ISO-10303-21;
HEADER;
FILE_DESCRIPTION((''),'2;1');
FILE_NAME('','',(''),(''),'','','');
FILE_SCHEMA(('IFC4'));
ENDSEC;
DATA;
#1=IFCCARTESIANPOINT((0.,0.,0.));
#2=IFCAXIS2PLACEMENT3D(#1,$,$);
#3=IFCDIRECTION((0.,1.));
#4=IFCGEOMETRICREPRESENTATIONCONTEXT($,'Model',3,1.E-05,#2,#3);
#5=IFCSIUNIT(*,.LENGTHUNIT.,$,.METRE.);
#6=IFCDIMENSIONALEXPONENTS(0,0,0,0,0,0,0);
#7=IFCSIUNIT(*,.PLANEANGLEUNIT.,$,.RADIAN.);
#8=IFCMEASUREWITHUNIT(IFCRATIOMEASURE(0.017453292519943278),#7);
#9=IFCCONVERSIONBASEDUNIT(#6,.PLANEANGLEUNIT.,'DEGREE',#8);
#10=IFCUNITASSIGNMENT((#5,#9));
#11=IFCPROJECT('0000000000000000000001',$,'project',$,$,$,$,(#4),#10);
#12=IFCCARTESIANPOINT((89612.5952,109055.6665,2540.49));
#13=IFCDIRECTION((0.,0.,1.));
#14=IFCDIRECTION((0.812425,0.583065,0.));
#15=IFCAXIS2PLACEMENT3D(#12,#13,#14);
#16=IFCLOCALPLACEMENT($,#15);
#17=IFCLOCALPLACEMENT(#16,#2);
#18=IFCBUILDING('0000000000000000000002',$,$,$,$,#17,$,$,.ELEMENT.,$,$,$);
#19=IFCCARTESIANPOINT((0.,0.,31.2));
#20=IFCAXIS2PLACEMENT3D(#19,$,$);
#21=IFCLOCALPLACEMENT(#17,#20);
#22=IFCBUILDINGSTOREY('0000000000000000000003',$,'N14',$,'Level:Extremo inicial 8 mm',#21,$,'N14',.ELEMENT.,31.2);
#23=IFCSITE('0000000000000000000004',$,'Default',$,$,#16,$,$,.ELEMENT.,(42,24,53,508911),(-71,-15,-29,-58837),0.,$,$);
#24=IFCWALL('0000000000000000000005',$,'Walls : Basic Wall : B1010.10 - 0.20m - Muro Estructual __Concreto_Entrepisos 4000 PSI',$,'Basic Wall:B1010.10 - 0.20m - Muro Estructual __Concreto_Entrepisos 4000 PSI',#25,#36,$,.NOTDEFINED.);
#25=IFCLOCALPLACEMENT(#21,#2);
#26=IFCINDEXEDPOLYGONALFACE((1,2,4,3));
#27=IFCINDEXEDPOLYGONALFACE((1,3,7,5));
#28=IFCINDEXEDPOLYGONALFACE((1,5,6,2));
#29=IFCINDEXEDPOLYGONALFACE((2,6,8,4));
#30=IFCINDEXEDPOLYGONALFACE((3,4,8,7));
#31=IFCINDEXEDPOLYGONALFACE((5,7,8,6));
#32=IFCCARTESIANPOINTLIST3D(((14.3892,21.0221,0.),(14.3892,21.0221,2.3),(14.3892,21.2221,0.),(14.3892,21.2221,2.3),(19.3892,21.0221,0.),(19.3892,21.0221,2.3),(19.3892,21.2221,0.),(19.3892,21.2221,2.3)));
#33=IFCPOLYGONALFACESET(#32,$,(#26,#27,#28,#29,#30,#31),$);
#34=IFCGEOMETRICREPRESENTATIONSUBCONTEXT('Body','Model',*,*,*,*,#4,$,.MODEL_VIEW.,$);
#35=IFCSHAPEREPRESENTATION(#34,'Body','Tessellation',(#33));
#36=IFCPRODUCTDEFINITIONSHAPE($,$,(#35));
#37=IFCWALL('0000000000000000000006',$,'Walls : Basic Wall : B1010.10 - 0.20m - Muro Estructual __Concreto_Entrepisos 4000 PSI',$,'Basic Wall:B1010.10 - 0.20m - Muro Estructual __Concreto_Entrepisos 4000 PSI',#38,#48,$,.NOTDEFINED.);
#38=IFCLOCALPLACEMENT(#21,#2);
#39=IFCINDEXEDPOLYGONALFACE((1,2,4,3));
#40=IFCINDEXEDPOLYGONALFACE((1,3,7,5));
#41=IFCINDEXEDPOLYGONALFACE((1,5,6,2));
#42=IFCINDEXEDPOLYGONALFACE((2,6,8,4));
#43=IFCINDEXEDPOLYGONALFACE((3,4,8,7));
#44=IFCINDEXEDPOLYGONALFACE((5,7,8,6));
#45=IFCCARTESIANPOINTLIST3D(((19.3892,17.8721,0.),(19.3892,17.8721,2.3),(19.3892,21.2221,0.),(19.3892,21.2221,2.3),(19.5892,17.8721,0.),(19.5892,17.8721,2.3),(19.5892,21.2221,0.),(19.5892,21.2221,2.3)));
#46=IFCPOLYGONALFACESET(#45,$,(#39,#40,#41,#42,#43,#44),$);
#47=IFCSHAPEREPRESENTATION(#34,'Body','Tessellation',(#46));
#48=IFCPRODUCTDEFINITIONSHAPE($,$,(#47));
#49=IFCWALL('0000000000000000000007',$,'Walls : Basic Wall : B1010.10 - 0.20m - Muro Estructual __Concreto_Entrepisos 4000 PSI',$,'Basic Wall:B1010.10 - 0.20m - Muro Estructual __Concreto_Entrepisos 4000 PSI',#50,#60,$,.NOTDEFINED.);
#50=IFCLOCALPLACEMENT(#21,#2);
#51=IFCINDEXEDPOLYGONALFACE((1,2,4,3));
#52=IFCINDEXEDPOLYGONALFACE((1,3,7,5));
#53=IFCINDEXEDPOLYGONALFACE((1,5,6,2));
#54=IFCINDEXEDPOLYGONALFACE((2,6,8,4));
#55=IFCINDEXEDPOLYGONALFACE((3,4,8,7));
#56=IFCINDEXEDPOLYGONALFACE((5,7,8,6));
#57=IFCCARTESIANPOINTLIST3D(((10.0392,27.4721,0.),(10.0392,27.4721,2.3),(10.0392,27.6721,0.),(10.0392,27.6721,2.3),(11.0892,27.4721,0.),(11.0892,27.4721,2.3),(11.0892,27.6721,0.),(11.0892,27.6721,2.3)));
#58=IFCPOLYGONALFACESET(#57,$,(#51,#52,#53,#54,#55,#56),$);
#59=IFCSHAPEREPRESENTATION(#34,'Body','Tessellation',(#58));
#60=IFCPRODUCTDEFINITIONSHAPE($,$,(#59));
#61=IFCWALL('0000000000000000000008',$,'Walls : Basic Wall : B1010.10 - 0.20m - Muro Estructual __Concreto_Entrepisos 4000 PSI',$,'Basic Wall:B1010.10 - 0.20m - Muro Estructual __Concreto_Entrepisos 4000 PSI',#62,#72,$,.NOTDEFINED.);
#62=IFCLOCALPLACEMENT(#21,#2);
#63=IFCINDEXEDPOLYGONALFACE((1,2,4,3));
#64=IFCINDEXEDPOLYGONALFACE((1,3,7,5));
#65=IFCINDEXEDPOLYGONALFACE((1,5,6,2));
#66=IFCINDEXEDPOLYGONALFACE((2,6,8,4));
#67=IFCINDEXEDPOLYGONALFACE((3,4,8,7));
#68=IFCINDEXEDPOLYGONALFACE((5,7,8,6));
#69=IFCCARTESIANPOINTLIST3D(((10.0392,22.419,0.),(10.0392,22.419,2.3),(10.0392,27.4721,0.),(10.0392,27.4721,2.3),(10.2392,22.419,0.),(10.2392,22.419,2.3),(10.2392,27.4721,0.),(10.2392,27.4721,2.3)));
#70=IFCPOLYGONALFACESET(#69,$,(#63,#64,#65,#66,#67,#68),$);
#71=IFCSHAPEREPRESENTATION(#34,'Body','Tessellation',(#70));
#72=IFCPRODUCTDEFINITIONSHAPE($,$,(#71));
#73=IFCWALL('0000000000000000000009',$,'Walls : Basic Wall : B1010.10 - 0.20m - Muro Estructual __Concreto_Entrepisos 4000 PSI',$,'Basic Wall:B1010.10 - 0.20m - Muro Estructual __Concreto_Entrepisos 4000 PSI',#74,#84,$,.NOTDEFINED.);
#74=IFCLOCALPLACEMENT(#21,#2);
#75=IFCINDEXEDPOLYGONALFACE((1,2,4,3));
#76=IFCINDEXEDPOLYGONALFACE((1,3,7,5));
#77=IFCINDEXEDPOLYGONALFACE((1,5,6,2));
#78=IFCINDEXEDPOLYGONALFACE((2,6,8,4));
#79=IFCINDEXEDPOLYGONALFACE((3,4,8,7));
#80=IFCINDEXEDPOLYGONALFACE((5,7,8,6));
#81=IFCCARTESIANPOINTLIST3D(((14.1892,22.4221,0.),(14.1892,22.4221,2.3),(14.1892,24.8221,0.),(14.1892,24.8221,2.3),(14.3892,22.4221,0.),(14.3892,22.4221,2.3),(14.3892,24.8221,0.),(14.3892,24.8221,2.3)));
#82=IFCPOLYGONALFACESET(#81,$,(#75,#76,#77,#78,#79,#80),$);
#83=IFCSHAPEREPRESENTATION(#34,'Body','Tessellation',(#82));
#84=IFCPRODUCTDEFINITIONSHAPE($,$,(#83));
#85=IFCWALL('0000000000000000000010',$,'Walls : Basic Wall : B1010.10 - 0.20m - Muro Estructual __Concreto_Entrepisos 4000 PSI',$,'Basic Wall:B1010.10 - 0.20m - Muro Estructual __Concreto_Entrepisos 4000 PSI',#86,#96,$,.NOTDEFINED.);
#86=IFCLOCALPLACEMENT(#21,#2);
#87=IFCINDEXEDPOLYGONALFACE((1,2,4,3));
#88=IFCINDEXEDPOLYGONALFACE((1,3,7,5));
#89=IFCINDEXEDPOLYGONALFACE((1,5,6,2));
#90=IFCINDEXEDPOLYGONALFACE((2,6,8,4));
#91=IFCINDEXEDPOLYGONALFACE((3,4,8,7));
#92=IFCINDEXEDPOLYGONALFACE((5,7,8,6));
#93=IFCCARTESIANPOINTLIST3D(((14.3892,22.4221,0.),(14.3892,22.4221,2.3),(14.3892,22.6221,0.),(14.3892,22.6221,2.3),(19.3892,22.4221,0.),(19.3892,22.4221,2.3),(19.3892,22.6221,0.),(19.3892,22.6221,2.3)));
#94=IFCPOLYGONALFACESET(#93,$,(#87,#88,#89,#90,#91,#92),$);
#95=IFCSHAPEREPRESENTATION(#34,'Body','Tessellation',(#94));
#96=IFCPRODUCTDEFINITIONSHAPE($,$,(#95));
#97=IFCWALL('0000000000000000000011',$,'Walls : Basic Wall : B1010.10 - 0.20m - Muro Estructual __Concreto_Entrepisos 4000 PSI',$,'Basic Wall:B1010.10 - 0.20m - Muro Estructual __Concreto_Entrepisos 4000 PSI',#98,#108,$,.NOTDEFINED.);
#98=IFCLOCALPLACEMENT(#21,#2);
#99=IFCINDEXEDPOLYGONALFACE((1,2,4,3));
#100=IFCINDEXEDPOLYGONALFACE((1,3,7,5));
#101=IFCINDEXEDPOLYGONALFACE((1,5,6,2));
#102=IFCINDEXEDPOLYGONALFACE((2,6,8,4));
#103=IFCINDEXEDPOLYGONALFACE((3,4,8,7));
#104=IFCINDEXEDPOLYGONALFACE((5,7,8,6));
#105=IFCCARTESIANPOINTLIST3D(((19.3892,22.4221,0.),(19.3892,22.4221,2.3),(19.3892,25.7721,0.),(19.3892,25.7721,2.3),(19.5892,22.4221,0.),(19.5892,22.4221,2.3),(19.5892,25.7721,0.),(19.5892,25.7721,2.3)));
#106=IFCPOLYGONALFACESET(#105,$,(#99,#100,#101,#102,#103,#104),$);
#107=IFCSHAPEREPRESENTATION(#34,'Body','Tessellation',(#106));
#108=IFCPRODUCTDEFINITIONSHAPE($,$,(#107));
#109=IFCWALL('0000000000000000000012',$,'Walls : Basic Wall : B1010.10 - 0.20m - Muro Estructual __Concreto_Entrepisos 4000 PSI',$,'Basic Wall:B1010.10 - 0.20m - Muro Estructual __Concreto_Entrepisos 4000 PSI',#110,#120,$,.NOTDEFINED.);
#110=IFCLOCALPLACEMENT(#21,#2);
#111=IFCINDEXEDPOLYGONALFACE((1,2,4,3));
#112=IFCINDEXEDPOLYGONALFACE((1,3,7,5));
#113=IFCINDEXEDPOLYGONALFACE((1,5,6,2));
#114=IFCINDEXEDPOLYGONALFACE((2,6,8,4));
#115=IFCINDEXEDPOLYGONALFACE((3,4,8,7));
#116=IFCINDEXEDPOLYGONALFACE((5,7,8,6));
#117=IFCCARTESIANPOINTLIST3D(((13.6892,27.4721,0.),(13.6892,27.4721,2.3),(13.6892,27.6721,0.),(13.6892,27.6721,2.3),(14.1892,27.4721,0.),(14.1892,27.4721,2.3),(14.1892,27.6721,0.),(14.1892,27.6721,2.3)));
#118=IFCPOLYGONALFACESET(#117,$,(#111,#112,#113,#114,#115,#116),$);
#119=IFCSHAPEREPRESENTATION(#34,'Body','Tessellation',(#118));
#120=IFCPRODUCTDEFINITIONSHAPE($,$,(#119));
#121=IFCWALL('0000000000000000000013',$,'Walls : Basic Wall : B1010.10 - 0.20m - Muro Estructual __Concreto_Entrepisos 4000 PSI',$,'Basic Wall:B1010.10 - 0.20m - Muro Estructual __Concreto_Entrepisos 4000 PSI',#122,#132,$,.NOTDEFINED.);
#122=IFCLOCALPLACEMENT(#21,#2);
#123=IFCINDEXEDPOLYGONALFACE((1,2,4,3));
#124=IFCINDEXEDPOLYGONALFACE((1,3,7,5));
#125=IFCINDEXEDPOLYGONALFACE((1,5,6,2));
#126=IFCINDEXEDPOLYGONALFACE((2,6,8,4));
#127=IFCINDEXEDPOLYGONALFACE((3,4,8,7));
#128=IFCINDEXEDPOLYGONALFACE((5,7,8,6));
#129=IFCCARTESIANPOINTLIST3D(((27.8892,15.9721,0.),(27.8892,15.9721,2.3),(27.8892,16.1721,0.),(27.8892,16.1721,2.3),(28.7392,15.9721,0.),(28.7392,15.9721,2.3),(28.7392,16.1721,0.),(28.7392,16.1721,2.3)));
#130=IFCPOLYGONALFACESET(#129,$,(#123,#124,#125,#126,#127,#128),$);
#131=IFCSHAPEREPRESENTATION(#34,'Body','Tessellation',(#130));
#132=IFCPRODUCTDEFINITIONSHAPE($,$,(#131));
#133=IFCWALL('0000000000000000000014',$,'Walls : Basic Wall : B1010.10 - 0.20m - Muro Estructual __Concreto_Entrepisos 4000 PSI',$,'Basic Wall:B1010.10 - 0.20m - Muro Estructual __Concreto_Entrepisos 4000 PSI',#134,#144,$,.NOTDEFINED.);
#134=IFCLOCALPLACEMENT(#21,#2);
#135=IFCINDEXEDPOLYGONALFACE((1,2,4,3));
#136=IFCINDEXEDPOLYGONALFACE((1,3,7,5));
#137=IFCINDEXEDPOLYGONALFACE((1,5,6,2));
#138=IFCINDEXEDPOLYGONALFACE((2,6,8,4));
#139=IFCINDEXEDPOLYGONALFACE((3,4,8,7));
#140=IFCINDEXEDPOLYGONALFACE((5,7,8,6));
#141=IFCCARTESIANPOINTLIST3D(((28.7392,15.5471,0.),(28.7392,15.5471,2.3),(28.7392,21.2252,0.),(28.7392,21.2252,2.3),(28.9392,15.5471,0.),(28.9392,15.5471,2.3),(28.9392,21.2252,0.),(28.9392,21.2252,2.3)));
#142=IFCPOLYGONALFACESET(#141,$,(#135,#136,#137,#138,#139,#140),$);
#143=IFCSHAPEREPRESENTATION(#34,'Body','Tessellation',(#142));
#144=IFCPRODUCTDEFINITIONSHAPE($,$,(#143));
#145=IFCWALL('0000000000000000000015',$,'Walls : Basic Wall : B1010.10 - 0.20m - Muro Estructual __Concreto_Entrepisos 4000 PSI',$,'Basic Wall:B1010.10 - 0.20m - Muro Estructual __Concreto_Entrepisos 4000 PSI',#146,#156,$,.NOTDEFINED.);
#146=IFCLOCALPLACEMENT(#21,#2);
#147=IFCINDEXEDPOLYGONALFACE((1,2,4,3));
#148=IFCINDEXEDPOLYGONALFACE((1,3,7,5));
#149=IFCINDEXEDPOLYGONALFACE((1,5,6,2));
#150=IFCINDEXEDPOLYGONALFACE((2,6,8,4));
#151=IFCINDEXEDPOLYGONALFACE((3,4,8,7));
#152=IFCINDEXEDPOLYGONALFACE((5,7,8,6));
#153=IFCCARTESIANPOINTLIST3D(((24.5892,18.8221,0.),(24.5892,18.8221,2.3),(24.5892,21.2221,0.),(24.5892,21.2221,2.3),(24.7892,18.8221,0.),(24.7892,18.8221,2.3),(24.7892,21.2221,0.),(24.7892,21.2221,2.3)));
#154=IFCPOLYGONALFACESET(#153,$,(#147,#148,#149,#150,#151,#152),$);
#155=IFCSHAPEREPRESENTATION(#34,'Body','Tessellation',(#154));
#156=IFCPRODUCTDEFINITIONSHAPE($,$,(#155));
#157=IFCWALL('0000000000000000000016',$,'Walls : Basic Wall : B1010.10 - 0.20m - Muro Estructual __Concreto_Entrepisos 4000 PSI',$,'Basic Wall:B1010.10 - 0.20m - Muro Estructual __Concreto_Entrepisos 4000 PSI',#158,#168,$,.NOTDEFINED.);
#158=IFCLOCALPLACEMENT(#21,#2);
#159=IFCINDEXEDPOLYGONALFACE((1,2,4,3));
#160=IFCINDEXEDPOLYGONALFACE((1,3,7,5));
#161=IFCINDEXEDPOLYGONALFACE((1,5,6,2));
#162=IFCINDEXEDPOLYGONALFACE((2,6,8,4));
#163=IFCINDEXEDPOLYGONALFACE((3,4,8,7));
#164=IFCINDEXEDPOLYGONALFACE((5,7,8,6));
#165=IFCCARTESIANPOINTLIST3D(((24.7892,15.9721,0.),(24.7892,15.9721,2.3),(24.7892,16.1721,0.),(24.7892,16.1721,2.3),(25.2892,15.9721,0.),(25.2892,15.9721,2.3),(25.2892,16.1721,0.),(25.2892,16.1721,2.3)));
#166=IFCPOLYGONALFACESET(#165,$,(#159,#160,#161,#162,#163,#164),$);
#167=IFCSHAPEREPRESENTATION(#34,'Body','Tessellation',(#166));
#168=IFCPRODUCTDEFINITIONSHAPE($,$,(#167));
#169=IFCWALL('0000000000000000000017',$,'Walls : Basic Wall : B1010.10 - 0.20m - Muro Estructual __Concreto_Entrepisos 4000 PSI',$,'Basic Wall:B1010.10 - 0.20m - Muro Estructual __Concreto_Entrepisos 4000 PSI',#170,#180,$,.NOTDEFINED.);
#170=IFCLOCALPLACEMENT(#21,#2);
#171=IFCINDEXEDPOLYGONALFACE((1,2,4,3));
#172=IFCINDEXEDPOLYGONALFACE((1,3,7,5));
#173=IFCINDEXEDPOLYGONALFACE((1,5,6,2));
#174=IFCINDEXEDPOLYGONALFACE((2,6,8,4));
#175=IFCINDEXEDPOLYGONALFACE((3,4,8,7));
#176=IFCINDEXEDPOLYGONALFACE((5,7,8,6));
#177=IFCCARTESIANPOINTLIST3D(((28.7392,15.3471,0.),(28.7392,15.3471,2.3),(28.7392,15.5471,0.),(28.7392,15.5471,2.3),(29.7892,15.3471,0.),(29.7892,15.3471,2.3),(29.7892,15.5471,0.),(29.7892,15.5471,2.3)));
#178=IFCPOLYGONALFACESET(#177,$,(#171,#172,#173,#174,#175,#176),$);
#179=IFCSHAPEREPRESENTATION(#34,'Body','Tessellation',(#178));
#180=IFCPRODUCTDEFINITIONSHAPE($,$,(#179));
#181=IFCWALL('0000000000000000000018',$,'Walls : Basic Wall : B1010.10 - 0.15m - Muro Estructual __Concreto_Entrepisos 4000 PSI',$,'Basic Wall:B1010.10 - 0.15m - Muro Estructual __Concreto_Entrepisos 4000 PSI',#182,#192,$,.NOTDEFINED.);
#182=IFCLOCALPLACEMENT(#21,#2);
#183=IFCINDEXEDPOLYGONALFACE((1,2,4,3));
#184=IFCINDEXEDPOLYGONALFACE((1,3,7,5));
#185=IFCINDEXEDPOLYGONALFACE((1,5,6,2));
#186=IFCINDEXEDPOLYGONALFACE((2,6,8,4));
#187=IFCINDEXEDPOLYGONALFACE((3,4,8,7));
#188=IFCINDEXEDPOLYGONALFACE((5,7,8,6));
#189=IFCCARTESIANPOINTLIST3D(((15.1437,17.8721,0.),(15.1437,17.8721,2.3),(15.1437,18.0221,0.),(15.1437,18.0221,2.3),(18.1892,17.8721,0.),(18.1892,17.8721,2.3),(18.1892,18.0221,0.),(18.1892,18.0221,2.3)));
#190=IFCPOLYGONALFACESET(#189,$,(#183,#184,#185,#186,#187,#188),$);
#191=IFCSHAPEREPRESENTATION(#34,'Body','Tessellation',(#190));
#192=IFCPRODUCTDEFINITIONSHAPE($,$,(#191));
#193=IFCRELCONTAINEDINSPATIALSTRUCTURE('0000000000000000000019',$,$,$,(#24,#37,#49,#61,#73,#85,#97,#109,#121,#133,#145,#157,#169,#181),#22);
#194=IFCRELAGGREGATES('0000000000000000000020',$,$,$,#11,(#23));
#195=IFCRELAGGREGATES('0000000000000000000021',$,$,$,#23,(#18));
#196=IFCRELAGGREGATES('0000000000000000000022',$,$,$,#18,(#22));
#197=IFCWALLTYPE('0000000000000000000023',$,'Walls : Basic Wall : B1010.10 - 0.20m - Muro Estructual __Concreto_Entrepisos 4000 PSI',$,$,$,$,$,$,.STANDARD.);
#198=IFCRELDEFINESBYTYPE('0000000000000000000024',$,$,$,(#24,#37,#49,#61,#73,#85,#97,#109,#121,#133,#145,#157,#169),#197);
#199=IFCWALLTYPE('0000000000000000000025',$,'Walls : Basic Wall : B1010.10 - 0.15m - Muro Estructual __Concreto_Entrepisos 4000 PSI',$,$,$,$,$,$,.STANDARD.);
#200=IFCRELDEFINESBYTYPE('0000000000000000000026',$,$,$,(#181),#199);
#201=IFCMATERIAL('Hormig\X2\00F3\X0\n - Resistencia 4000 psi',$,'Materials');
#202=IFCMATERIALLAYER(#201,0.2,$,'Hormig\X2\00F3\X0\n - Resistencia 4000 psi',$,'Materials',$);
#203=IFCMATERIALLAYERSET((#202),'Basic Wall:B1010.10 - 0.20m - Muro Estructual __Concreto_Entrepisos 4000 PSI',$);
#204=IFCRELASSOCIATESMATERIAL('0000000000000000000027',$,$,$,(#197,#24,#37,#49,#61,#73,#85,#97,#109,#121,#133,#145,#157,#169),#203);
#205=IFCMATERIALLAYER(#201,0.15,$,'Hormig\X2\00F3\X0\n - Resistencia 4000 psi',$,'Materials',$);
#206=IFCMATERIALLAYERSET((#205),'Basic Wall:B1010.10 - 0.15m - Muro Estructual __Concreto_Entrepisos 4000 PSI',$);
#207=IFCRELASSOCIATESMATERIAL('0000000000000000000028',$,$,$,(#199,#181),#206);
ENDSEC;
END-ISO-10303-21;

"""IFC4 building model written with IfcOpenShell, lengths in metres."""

from ifc_helpers import new_model, entity, si_unit, converted_unit, direction, frame, frame_2d, origin, place, context, subcontext, project, spatial, rectangle, extrude, material, layer, layer_set, layer_usage, type_object, element, save


model = new_model("IFC4")

# Units and contexts
model_context = context("Model", 3, precision=1e-05, world=origin(), true_north=direction((0.0, 1.0)))
body_context = subcontext(model_context, "Body", "Model", "MODEL_VIEW")
ifc_project = project(units=[si_unit("LENGTHUNIT", "METRE"), converted_unit("PLANEANGLEUNIT", "DEGREE", entity("IfcRatioMeasure", 0.017453292519943278), si_unit("PLANEANGLEUNIT", "RADIAN"), dimensions=[0, 0, 0, 0, 0, 0, 0])], contexts=[model_context])

# Site, building, storey
site_placement = place(None, frame((89612.5952, 109055.6665, 2540.49), z_axis=(0.0, 0.0, 1.0), x_axis=(0.812425, 0.583065, 0.0)))
site = spatial("IfcSite", under=ifc_project, at=site_placement, Name="Default", CompositionType="ELEMENT", RefLatitude=(42, 24, 53, 508911), RefLongitude=(-71, -15, -29, -58837), RefElevation=0.0)
building_placement = place(site_placement, origin())
building = spatial("IfcBuilding", under=site, at=building_placement, CompositionType="ELEMENT")
storey_placement = place(building_placement, frame((0.0, 0.0, 31.2)))
storey = spatial("IfcBuildingStorey", under=building, at=storey_placement, Name="N14", ObjectType="Level:Extremo inicial 8 mm", LongName="N14", CompositionType="ELEMENT", Elevation=31.2)

# Walls
ifc_material = material(Name="Hormigón - Resistencia 4000 psi", Category="Materials")
ifc_layer_1 = layer(ifc_material, 0.2, Name="Hormigón - Resistencia 4000 psi", Category="Materials")
ifc_layer_set_1 = layer_set([ifc_layer_1], Name="Basic Wall:B1010.10 - 0.20m - Muro Estructual __Concreto_Entrepisos 4000 PSI")
ifc_layer_usage_1 = layer_usage(ifc_layer_set_1, "AXIS2", "NEGATIVE", 0.1)
wall_type_1 = type_object("IfcWallType", Name="Walls : Basic Wall : B1010.10 - 0.20m - Muro Estructual __Concreto_Entrepisos 4000 PSI", PredefinedType="STANDARD", material=ifc_layer_set_1)
wall_1_placement = place(storey_placement, frame((14.3892, 21.1221, 0.0)))
element("IfcWall", 1, at=wall_1_placement, inside=storey, type_object=wall_type_1, material=ifc_layer_usage_1, Name="Walls : Basic Wall : B1010.10 - 0.20m - Muro Estructual __Concreto_Entrepisos 4000 PSI", ObjectType="Basic Wall:B1010.10 - 0.20m - Muro Estructual __Concreto_Entrepisos 4000 PSI", PredefinedType="NOTDEFINED", context=body_context, shape_type="SweptSolid", body=[
    extrude(rectangle(XDim=5.0, YDim=0.2, at=frame_2d((2.5, 0.0), x_axis=(-1.0, 0.0))), origin(), (0.0, 0.0, 1.0), 2.3),
])
ifc_layer_usage_2 = layer_usage(ifc_layer_set_1, "AXIS2", "NEGATIVE", 0.1)
wall_2_placement = place(storey_placement, frame((19.4892, 21.2221, 0.0), z_axis=(0.0, 0.0, 1.0), x_axis=(0.0, -1.0, 0.0)))
element("IfcWall", 2, at=wall_2_placement, inside=storey, type_object=wall_type_1, material=ifc_layer_usage_2, Name="Walls : Basic Wall : B1010.10 - 0.20m - Muro Estructual __Concreto_Entrepisos 4000 PSI", ObjectType="Basic Wall:B1010.10 - 0.20m - Muro Estructual __Concreto_Entrepisos 4000 PSI", PredefinedType="NOTDEFINED", context=body_context, shape_type="SweptSolid", body=[
    extrude(rectangle(XDim=3.35, YDim=0.2, at=frame_2d((1.675, 0.0), x_axis=(-1.0, 0.0))), origin(), (0.0, 0.0, 1.0), 2.3),
])
ifc_layer_usage_3 = layer_usage(ifc_layer_set_1, "AXIS2", "POSITIVE", -0.1)
wall_3_placement = place(storey_placement, frame((11.0892, 27.5721, 0.0), z_axis=(0.0, 0.0, 1.0), x_axis=(-1.0, 0.0, 0.0)))
element("IfcWall", 3, at=wall_3_placement, inside=storey, type_object=wall_type_1, material=ifc_layer_usage_3, Name="Walls : Basic Wall : B1010.10 - 0.20m - Muro Estructual __Concreto_Entrepisos 4000 PSI", ObjectType="Basic Wall:B1010.10 - 0.20m - Muro Estructual __Concreto_Entrepisos 4000 PSI", PredefinedType="NOTDEFINED", context=body_context, shape_type="SweptSolid", body=[
    extrude(rectangle(XDim=1.05, YDim=0.2, at=frame_2d((0.525, 0.0), x_axis=(-1.0, 0.0))), origin(), (0.0, 0.0, 1.0), 2.3),
])
ifc_layer_usage_4 = layer_usage(ifc_layer_set_1, "AXIS2", "POSITIVE", -0.1)
wall_4_placement = place(storey_placement, frame((10.1392, 27.4721, 0.0), z_axis=(0.0, 0.0, 1.0), x_axis=(0.0, -1.0, 0.0)))
element("IfcWall", 4, at=wall_4_placement, inside=storey, type_object=wall_type_1, material=ifc_layer_usage_4, Name="Walls : Basic Wall : B1010.10 - 0.20m - Muro Estructual __Concreto_Entrepisos 4000 PSI", ObjectType="Basic Wall:B1010.10 - 0.20m - Muro Estructual __Concreto_Entrepisos 4000 PSI", PredefinedType="NOTDEFINED", context=body_context, shape_type="SweptSolid", body=[
    extrude(rectangle(XDim=5.0531, YDim=0.2, at=frame_2d((2.5265, 0.0), x_axis=(-1.0, 0.0))), origin(), (0.0, 0.0, 1.0), 2.3),
])
ifc_layer_usage_5 = layer_usage(ifc_layer_set_1, "AXIS2", "POSITIVE", -0.1)
wall_5_placement = place(storey_placement, frame((14.2892, 24.8221, 0.0), z_axis=(0.0, 0.0, 1.0), x_axis=(0.0, -1.0, 0.0)))
element("IfcWall", 5, at=wall_5_placement, inside=storey, type_object=wall_type_1, material=ifc_layer_usage_5, Name="Walls : Basic Wall : B1010.10 - 0.20m - Muro Estructual __Concreto_Entrepisos 4000 PSI", ObjectType="Basic Wall:B1010.10 - 0.20m - Muro Estructual __Concreto_Entrepisos 4000 PSI", PredefinedType="NOTDEFINED", context=body_context, shape_type="SweptSolid", body=[
    extrude(rectangle(XDim=2.4, YDim=0.2, at=frame_2d((1.2, 0.0), x_axis=(-1.0, 0.0))), origin(), (0.0, 0.0, 1.0), 2.3),
])
ifc_layer_usage_6 = layer_usage(ifc_layer_set_1, "AXIS2", "POSITIVE", -0.1)
wall_6_placement = place(storey_placement, frame((14.3892, 22.5221, 0.0)))
element("IfcWall", 6, at=wall_6_placement, inside=storey, type_object=wall_type_1, material=ifc_layer_usage_6, Name="Walls : Basic Wall : B1010.10 - 0.20m - Muro Estructual __Concreto_Entrepisos 4000 PSI", ObjectType="Basic Wall:B1010.10 - 0.20m - Muro Estructual __Concreto_Entrepisos 4000 PSI", PredefinedType="NOTDEFINED", context=body_context, shape_type="SweptSolid", body=[
    extrude(rectangle(XDim=5.0, YDim=0.2, at=frame_2d((2.5, 0.0), x_axis=(-1.0, 0.0))), origin(), (0.0, 0.0, 1.0), 2.3),
])
ifc_layer_usage_7 = layer_usage(ifc_layer_set_1, "AXIS2", "POSITIVE", -0.1)
wall_7_placement = place(storey_placement, frame((19.4892, 22.4221, 0.0), z_axis=(0.0, 0.0, 1.0), x_axis=(0.0, 1.0, 0.0)))
element("IfcWall", 7, at=wall_7_placement, inside=storey, type_object=wall_type_1, material=ifc_layer_usage_7, Name="Walls : Basic Wall : B1010.10 - 0.20m - Muro Estructual __Concreto_Entrepisos 4000 PSI", ObjectType="Basic Wall:B1010.10 - 0.20m - Muro Estructual __Concreto_Entrepisos 4000 PSI", PredefinedType="NOTDEFINED", context=body_context, shape_type="SweptSolid", body=[
    extrude(rectangle(XDim=3.35, YDim=0.2, at=frame_2d((1.675, 0.0), x_axis=(-1.0, 0.0))), origin(), (0.0, 0.0, 1.0), 2.3),
])
ifc_layer_usage_8 = layer_usage(ifc_layer_set_1, "AXIS2", "POSITIVE", -0.1)
wall_8_placement = place(storey_placement, frame((13.6892, 27.5721, 0.0)))
element("IfcWall", 8, at=wall_8_placement, inside=storey, type_object=wall_type_1, material=ifc_layer_usage_8, Name="Walls : Basic Wall : B1010.10 - 0.20m - Muro Estructual __Concreto_Entrepisos 4000 PSI", ObjectType="Basic Wall:B1010.10 - 0.20m - Muro Estructual __Concreto_Entrepisos 4000 PSI", PredefinedType="NOTDEFINED", context=body_context, shape_type="SweptSolid", body=[
    extrude(rectangle(XDim=0.5, YDim=0.2, at=frame_2d((0.25, 0.0), x_axis=(-1.0, 0.0))), origin(), (0.0, 0.0, 1.0), 2.3),
])
ifc_layer_usage_9 = layer_usage(ifc_layer_set_1, "AXIS2", "POSITIVE", -0.1)
wall_9_placement = place(storey_placement, frame((27.8892, 16.0721, 0.0)))
element("IfcWall", 9, at=wall_9_placement, inside=storey, type_object=wall_type_1, material=ifc_layer_usage_9, Name="Walls : Basic Wall : B1010.10 - 0.20m - Muro Estructual __Concreto_Entrepisos 4000 PSI", ObjectType="Basic Wall:B1010.10 - 0.20m - Muro Estructual __Concreto_Entrepisos 4000 PSI", PredefinedType="NOTDEFINED", context=body_context, shape_type="SweptSolid", body=[
    extrude(rectangle(XDim=0.85, YDim=0.2, at=frame_2d((0.425, 0.0), x_axis=(-1.0, 0.0))), origin(), (0.0, 0.0, 1.0), 2.3),
])
ifc_layer_usage_10 = layer_usage(ifc_layer_set_1, "AXIS2", "POSITIVE", -0.1)
wall_10_placement = place(storey_placement, frame((28.8392, 15.5471, 0.0), z_axis=(0.0, 0.0, 1.0), x_axis=(0.0, 1.0, 0.0)))
element("IfcWall", 10, at=wall_10_placement, inside=storey, type_object=wall_type_1, material=ifc_layer_usage_10, Name="Walls : Basic Wall : B1010.10 - 0.20m - Muro Estructual __Concreto_Entrepisos 4000 PSI", ObjectType="Basic Wall:B1010.10 - 0.20m - Muro Estructual __Concreto_Entrepisos 4000 PSI", PredefinedType="NOTDEFINED", context=body_context, shape_type="SweptSolid", body=[
    extrude(rectangle(XDim=5.6781, YDim=0.2, at=frame_2d((2.839, 0.0), x_axis=(-1.0, 0.0))), origin(), (0.0, 0.0, 1.0), 2.3),
])
ifc_layer_usage_11 = layer_usage(ifc_layer_set_1, "AXIS2", "POSITIVE", -0.1)
wall_11_placement = place(storey_placement, frame((24.6892, 18.8221, 0.0), z_axis=(0.0, 0.0, 1.0), x_axis=(0.0, 1.0, 0.0)))
element("IfcWall", 11, at=wall_11_placement, inside=storey, type_object=wall_type_1, material=ifc_layer_usage_11, Name="Walls : Basic Wall : B1010.10 - 0.20m - Muro Estructual __Concreto_Entrepisos 4000 PSI", ObjectType="Basic Wall:B1010.10 - 0.20m - Muro Estructual __Concreto_Entrepisos 4000 PSI", PredefinedType="NOTDEFINED", context=body_context, shape_type="SweptSolid", body=[
    extrude(rectangle(XDim=2.4, YDim=0.2, at=frame_2d((1.2, 0.0), x_axis=(-1.0, 0.0))), origin(), (0.0, 0.0, 1.0), 2.3),
])
ifc_layer_usage_12 = layer_usage(ifc_layer_set_1, "AXIS2", "POSITIVE", -0.1)
wall_12_placement = place(storey_placement, frame((25.2892, 16.0721, 0.0), z_axis=(0.0, 0.0, 1.0), x_axis=(-1.0, 0.0, 0.0)))
element("IfcWall", 12, at=wall_12_placement, inside=storey, type_object=wall_type_1, material=ifc_layer_usage_12, Name="Walls : Basic Wall : B1010.10 - 0.20m - Muro Estructual __Concreto_Entrepisos 4000 PSI", ObjectType="Basic Wall:B1010.10 - 0.20m - Muro Estructual __Concreto_Entrepisos 4000 PSI", PredefinedType="NOTDEFINED", context=body_context, shape_type="SweptSolid", body=[
    extrude(rectangle(XDim=0.5, YDim=0.2, at=frame_2d((0.25, 0.0), x_axis=(-1.0, 0.0))), origin(), (0.0, 0.0, 1.0), 2.3),
])
ifc_layer_usage_13 = layer_usage(ifc_layer_set_1, "AXIS2", "NEGATIVE", 0.1)
wall_13_placement = place(storey_placement, frame((29.7892, 15.4471, 0.0), z_axis=(0.0, 0.0, 1.0), x_axis=(-1.0, 0.0, 0.0)))
element("IfcWall", 13, at=wall_13_placement, inside=storey, type_object=wall_type_1, material=ifc_layer_usage_13, Name="Walls : Basic Wall : B1010.10 - 0.20m - Muro Estructual __Concreto_Entrepisos 4000 PSI", ObjectType="Basic Wall:B1010.10 - 0.20m - Muro Estructual __Concreto_Entrepisos 4000 PSI", PredefinedType="NOTDEFINED", context=body_context, shape_type="SweptSolid", body=[
    extrude(rectangle(XDim=1.05, YDim=0.2, at=frame_2d((0.525, 0.0), x_axis=(-1.0, 0.0))), origin(), (0.0, 0.0, 1.0), 2.3),
])
ifc_layer_2 = layer(ifc_material, 0.15, Name="Hormigón - Resistencia 4000 psi", Category="Materials")
ifc_layer_set_2 = layer_set([ifc_layer_2], Name="Basic Wall:B1010.10 - 0.15m - Muro Estructual __Concreto_Entrepisos 4000 PSI")
ifc_layer_usage_14 = layer_usage(ifc_layer_set_2, "AXIS2", "NEGATIVE", 0.075)
wall_type_2 = type_object("IfcWallType", Name="Walls : Basic Wall : B1010.10 - 0.15m - Muro Estructual __Concreto_Entrepisos 4000 PSI", PredefinedType="STANDARD", material=ifc_layer_set_2)
wall_14_placement = place(storey_placement, frame((18.1892, 17.9471, 0.0), z_axis=(0.0, 0.0, 1.0), x_axis=(-1.0, 0.0, 0.0)))
element("IfcWall", 14, at=wall_14_placement, inside=storey, type_object=wall_type_2, material=ifc_layer_usage_14, Name="Walls : Basic Wall : B1010.10 - 0.15m - Muro Estructual __Concreto_Entrepisos 4000 PSI", ObjectType="Basic Wall:B1010.10 - 0.15m - Muro Estructual __Concreto_Entrepisos 4000 PSI", PredefinedType="NOTDEFINED", context=body_context, shape_type="SweptSolid", body=[
    extrude(rectangle(XDim=3.0455, YDim=0.15, at=frame_2d((1.5228, 0.0), x_axis=(-1.0, 0.0))), origin(), (0.0, 0.0, 1.0), 2.3),
])

save(model, "model.ifc")
